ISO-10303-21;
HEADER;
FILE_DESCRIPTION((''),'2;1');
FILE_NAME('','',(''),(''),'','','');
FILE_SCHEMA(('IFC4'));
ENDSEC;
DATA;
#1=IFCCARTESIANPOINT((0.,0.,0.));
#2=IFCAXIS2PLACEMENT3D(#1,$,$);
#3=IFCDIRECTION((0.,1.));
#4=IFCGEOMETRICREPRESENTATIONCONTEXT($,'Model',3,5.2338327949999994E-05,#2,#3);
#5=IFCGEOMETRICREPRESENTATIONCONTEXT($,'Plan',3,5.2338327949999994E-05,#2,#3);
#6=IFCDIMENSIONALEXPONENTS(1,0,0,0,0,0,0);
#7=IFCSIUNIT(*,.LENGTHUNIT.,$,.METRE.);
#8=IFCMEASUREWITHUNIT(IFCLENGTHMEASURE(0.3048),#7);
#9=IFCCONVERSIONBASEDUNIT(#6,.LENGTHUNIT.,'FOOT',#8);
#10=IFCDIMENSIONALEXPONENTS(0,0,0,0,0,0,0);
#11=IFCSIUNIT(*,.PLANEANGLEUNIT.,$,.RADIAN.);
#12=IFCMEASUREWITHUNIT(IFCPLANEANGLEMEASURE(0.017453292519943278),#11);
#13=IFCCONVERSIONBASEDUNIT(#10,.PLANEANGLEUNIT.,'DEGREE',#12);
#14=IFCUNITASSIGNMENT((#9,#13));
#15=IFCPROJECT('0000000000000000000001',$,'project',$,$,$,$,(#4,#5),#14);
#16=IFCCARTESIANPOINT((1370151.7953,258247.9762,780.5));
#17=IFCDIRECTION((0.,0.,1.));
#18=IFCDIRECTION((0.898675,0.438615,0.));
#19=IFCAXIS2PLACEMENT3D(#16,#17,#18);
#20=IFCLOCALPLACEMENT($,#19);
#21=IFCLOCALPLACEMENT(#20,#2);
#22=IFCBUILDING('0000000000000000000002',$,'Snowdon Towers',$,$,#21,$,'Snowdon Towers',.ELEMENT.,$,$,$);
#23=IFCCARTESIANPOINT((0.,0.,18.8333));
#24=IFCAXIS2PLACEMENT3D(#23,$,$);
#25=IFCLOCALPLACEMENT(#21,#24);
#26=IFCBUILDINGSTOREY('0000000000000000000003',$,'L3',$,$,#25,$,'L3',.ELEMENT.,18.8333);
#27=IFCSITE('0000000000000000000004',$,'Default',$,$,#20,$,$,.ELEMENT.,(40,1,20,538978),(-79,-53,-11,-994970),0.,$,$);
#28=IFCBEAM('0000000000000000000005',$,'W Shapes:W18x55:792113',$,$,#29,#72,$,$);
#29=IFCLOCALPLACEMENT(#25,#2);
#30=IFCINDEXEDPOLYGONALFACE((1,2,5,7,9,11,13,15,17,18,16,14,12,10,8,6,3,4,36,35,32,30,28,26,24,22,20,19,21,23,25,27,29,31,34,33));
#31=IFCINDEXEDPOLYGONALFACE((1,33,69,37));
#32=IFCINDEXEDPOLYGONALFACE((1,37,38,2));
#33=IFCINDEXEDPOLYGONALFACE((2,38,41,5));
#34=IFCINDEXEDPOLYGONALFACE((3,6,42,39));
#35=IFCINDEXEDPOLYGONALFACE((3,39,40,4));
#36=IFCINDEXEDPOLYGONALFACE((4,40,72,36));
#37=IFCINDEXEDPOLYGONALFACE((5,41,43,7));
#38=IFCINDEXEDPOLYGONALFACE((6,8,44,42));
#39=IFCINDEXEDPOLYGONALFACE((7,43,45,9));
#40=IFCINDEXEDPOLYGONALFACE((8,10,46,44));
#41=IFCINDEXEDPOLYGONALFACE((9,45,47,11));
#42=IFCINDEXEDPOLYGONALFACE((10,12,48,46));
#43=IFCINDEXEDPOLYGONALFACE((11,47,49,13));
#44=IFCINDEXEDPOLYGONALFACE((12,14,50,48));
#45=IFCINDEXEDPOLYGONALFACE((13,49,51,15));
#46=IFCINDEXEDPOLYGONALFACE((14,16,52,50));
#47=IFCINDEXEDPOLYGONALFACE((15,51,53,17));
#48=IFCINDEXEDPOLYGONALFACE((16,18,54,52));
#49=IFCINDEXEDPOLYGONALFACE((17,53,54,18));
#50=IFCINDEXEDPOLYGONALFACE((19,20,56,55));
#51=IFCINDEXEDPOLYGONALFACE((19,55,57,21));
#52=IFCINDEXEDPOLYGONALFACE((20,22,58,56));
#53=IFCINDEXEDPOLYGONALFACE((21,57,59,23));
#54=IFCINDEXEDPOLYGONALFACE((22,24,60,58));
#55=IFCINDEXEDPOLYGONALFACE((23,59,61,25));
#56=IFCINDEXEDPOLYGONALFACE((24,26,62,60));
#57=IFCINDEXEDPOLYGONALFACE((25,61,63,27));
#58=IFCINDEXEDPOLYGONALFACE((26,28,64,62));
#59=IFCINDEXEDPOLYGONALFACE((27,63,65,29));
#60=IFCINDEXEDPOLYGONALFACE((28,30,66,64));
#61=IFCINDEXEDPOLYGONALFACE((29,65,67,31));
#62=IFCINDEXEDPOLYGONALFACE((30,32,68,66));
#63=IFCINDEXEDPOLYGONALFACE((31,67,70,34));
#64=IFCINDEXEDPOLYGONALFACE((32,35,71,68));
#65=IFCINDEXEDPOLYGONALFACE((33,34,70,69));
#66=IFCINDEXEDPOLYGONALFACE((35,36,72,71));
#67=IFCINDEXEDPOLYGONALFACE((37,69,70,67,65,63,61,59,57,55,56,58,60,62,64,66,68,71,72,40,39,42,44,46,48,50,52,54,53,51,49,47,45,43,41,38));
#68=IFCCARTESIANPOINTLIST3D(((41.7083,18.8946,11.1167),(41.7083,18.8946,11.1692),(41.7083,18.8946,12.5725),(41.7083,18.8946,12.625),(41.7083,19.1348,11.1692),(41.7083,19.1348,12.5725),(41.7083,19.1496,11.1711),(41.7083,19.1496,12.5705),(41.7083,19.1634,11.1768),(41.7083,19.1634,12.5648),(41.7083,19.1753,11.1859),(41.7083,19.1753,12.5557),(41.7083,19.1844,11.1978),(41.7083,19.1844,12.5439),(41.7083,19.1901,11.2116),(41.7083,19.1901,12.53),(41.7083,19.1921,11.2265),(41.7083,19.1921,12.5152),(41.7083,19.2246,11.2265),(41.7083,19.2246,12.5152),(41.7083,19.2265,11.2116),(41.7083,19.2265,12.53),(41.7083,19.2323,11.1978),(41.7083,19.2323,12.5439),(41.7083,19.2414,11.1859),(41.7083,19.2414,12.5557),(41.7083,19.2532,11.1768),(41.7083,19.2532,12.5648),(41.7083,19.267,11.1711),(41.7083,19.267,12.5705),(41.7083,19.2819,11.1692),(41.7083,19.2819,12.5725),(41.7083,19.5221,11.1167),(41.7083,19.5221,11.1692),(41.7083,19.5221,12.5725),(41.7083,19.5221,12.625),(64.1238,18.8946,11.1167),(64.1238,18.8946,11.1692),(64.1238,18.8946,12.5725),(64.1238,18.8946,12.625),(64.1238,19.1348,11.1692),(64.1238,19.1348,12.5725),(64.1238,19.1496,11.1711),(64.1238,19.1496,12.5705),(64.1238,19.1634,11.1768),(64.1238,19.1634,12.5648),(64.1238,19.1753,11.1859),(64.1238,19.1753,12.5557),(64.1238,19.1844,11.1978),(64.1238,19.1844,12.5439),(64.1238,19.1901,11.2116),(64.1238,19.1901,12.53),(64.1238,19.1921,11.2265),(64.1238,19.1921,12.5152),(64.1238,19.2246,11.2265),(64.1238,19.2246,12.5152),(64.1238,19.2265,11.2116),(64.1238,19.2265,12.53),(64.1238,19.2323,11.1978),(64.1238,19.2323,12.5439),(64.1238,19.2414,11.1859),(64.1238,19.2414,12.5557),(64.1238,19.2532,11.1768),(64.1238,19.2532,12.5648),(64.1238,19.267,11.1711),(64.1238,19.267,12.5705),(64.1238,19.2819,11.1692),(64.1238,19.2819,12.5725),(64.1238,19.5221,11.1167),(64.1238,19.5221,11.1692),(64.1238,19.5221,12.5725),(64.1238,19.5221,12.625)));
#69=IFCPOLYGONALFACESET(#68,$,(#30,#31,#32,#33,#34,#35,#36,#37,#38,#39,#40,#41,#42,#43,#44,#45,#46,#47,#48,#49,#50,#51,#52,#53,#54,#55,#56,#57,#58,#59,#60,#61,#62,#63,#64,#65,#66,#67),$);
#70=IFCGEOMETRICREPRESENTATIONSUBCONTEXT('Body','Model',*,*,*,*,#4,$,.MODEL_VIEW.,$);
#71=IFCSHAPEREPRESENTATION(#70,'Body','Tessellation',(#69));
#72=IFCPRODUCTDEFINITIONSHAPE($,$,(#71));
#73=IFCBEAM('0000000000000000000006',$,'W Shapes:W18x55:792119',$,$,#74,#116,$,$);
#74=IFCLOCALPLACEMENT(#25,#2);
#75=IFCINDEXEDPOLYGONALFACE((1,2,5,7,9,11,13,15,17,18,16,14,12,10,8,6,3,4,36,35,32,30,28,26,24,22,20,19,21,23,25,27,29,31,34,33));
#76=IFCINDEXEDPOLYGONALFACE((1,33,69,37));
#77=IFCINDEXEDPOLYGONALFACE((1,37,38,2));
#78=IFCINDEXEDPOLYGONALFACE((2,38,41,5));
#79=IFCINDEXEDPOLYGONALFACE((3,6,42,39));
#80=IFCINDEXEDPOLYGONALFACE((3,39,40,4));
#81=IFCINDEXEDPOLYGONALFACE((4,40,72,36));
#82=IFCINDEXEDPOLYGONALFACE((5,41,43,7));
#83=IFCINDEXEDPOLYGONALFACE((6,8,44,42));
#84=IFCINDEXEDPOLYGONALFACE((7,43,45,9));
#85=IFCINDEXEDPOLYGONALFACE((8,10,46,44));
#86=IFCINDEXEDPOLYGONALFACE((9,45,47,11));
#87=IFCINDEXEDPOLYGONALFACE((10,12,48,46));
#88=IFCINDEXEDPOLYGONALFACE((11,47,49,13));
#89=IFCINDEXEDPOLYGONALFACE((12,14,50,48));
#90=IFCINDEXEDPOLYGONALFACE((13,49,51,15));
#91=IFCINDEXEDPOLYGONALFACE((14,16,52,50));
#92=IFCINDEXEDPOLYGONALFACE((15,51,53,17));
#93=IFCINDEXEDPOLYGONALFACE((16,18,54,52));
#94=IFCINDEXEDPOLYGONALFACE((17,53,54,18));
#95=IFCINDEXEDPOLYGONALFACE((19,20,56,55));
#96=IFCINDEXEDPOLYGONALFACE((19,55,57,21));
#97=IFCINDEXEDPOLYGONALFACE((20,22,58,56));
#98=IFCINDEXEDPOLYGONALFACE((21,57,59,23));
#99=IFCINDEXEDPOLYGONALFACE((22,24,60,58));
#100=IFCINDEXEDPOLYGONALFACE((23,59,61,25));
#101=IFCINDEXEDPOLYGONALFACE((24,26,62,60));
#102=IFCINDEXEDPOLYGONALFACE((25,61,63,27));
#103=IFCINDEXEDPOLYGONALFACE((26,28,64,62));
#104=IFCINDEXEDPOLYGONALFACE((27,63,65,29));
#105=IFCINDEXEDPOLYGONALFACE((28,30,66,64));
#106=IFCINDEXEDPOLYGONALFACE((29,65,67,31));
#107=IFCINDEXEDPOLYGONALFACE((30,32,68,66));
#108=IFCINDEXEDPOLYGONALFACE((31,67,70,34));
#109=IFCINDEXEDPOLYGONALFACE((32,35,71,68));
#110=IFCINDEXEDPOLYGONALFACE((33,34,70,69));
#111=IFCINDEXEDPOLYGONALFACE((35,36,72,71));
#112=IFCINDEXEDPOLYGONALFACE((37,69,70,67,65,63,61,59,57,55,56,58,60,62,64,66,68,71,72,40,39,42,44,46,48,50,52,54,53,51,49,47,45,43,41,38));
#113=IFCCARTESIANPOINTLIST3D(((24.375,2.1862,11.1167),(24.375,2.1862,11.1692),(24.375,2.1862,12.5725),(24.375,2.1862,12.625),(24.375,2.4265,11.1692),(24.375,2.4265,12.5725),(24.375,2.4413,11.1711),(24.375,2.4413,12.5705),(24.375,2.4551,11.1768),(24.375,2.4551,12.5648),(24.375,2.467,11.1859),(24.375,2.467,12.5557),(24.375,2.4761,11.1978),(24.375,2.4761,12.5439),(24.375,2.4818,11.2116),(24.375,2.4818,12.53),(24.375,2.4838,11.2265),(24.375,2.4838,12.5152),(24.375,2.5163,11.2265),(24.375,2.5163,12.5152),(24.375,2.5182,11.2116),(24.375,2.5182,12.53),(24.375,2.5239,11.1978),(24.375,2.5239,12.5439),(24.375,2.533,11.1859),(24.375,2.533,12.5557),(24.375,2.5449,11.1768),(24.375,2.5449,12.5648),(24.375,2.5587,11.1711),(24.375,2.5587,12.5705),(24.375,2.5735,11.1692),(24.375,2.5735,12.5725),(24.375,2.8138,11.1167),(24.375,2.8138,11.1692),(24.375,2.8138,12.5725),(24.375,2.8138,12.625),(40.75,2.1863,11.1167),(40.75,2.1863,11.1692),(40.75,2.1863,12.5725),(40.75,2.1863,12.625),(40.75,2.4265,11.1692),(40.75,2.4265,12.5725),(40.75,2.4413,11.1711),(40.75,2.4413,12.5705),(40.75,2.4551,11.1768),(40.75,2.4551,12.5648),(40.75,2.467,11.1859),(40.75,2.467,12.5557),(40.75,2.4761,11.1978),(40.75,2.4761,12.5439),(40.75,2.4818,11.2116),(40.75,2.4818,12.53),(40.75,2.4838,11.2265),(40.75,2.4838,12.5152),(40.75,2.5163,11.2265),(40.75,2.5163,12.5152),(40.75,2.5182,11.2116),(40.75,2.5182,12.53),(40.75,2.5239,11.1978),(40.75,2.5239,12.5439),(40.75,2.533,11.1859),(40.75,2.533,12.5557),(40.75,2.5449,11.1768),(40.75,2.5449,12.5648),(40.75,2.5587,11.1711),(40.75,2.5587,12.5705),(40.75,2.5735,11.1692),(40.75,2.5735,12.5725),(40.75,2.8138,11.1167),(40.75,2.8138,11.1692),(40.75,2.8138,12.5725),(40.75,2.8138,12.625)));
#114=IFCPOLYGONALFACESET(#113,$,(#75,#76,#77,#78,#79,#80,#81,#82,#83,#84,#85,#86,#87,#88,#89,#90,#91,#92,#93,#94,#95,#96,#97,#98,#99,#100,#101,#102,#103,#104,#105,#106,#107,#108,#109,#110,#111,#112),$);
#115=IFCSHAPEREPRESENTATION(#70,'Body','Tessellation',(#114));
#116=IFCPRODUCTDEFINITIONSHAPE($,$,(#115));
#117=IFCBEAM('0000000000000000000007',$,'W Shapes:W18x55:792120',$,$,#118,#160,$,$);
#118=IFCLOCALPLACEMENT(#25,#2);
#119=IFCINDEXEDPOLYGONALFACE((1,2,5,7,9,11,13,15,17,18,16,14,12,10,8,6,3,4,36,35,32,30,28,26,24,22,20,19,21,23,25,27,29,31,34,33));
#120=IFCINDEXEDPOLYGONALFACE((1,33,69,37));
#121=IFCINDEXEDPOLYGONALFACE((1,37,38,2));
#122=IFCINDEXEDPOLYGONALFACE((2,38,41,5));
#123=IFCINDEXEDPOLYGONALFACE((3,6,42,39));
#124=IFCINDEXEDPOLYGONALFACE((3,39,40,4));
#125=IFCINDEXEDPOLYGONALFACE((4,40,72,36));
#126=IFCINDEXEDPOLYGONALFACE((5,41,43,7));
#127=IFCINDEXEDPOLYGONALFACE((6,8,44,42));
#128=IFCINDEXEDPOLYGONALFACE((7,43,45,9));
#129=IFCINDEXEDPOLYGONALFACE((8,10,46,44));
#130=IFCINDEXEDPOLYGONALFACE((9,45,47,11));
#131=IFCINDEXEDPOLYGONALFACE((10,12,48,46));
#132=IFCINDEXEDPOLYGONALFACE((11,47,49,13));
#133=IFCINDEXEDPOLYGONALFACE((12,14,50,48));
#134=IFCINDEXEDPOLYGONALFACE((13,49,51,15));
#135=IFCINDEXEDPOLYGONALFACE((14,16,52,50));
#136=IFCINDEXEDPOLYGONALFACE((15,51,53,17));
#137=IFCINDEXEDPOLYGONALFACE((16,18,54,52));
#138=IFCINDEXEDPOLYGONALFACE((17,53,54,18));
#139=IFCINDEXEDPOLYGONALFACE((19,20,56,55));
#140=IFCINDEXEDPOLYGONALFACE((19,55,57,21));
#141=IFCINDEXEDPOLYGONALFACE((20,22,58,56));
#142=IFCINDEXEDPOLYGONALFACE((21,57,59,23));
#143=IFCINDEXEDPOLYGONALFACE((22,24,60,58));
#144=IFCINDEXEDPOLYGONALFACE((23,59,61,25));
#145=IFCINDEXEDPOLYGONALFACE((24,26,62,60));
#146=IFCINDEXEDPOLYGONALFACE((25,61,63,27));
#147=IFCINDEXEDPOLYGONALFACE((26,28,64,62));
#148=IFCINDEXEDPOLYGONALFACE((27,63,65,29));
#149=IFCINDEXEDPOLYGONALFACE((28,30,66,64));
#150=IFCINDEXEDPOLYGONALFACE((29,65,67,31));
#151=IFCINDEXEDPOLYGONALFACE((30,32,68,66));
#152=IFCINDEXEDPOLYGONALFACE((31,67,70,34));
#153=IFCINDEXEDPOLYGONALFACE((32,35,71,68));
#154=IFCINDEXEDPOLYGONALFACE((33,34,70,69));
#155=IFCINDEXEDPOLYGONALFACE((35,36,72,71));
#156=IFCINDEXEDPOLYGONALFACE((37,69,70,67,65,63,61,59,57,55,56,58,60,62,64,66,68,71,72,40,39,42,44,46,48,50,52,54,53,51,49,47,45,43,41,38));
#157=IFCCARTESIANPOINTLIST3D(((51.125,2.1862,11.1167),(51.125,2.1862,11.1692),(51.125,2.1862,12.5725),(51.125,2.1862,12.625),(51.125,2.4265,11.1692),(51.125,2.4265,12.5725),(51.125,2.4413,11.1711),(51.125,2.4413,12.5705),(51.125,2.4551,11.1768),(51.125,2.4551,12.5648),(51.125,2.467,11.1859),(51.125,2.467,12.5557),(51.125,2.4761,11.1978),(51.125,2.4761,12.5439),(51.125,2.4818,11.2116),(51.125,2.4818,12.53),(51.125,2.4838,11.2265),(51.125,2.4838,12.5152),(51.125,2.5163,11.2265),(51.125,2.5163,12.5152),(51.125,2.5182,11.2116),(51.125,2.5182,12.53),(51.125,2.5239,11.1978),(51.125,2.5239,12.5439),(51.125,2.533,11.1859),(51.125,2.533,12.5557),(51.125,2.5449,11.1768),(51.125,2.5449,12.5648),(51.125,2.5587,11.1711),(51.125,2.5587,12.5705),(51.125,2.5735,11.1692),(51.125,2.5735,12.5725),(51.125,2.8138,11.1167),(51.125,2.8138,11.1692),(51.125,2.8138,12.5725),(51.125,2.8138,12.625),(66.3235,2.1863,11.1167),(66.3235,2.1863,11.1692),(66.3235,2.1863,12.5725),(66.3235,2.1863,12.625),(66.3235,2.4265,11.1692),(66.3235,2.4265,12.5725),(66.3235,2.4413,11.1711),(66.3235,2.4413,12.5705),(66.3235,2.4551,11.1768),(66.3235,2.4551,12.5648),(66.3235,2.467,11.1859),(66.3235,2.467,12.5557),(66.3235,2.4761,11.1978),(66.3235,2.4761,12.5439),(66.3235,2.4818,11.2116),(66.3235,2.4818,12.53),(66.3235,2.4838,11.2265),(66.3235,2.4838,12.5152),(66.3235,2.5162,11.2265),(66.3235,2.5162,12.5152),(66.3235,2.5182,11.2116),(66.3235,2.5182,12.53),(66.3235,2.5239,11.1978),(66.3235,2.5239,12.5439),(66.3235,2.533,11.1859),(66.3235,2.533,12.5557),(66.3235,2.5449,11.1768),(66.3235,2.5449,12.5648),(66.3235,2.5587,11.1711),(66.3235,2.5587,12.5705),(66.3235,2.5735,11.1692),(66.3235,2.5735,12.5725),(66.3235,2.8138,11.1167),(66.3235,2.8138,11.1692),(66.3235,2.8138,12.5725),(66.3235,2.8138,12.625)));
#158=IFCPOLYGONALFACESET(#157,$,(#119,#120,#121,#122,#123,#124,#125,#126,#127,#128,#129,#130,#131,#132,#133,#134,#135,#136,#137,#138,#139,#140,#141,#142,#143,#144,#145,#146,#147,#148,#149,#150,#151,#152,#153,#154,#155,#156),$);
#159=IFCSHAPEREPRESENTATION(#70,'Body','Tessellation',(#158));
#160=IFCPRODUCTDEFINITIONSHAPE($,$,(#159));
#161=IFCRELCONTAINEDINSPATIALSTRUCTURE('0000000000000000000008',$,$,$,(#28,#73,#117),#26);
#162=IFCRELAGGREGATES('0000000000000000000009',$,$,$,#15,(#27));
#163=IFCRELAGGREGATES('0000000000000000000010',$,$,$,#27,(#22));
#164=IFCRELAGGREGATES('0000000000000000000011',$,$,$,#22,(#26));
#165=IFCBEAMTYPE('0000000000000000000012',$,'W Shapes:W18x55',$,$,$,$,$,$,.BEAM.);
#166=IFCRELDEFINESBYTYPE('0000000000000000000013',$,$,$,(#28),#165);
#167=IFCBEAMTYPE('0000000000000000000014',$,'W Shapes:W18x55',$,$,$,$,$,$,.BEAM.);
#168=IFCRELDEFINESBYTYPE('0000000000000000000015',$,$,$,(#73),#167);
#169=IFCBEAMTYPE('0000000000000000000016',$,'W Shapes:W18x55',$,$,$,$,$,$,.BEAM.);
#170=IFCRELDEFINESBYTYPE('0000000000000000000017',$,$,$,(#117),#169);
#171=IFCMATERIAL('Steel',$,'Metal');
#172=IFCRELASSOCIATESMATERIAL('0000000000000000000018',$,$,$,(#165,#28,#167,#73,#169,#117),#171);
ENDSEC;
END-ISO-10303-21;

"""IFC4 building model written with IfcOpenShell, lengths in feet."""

from ifc_helpers import new_model, entity, si_unit, converted_unit, direction, frame, origin, place, context, subcontext, project, spatial, line, arc, indexed_curve, outline, extrude, source, transform, mapped, material, type_object, type_shapes, element, save


model = new_model("IFC4")

# Units and contexts
model_context = context("Model", 3, precision=5.2338327949999994e-05, world=origin(), true_north=direction((0.0, 1.0)))
plan_context = context("Plan", 3, precision=5.2338327949999994e-05, world=origin(), true_north=direction((0.0, 1.0)))
body_context = subcontext(model_context, "Body", "Model", "MODEL_VIEW")
ifc_project = project(units=[converted_unit("LENGTHUNIT", "FOOT", entity("IfcLengthMeasure", 0.3048), si_unit("LENGTHUNIT", "METRE"), dimensions=[1, 0, 0, 0, 0, 0, 0]), converted_unit("PLANEANGLEUNIT", "DEGREE", entity("IfcPlaneAngleMeasure", 0.017453292519943278), si_unit("PLANEANGLEUNIT", "RADIAN"), dimensions=[0, 0, 0, 0, 0, 0, 0])], contexts=[model_context, plan_context])

# Site, building, storey
site_placement = place(None, frame((1370151.7953, 258247.9762, 780.5), z_axis=(0.0, 0.0, 1.0), x_axis=(0.898675, 0.438615, 0.0)))
site = spatial("IfcSite", under=ifc_project, at=site_placement, Name="Default", CompositionType="ELEMENT", RefLatitude=(40, 1, 20, 538978), RefLongitude=(-79, -53, -11, -994970), RefElevation=0.0)
building_placement = place(site_placement, origin())
building = spatial("IfcBuilding", under=site, at=building_placement, Name="Snowdon Towers", LongName="Snowdon Towers", CompositionType="ELEMENT")
storey_placement = place(building_placement, frame((0.0, 0.0, 18.8333)))
storey = spatial("IfcBuildingStorey", under=building, at=storey_placement, Name="L3", LongName="L3", CompositionType="ELEMENT", Elevation=18.8333)

# Beams
ifc_material_1 = material(Name="Steel", Category="Metal")
beam_type_1 = type_object("IfcBeamType", Name="W Shapes:W18x55", PredefinedType="BEAM", material=ifc_material_1)
shared_shape_1 = source(origin(), body_context, "Body", "SweptSolid", [
    extrude(outline(indexed_curve([(-0.7542, -0.3138), (-0.7017, -0.3138), (-0.7017, -0.0735), (-0.6849, -0.033), (-0.6444, -0.0162), (0.6444, -0.0162), (0.6849, -0.033), (0.7017, -0.0735), (0.7017, -0.3138), (0.7542, -0.3138), (0.7542, 0.3138), (0.7017, 0.3138), (0.7017, 0.0735), (0.6849, 0.033), (0.6444, 0.0163), (-0.6444, 0.0163), (-0.6849, 0.033), (-0.7017, 0.0735), (-0.7017, 0.3137), (-0.7542, 0.3137)], segments=[line(1, 2, 3), arc(3, 4, 5), line(5, 6), arc(6, 7, 8), line(8, 9, 10, 11, 12, 13), arc(13, 14, 15), line(15, 16), arc(16, 17, 18), line(18, 19, 20, 1)], self_intersect=False)), frame((-11.5915, 0.0, 0.0), z_axis=(1.0, 0.0, 0.0), x_axis=(0.0, 0.0, -1.0)), (0.0, 0.0, 1.0), 22.4154),
])
type_shapes(beam_type_1, [shared_shape_1])
beam_1_placement = place(storey_placement, frame((53.2998, 19.2083, 11.8708)))
element("IfcBeam", 1, at=beam_1_placement, inside=storey, type_object=beam_type_1, material=ifc_material_1, Name="W Shapes:W18x55:792113", context=body_context, shape_type="MappedRepresentation", body=[
    mapped(shared_shape_1, transform((0.0, 0.0, 0.0), scale=1.0)),
])
beam_type_2 = type_object("IfcBeamType", Name="W Shapes:W18x55", PredefinedType="BEAM", material=ifc_material_1)
shared_shape_2 = source(origin(), body_context, "Body", "SweptSolid", [
    extrude(outline(indexed_curve([(-0.7542, -0.3138), (-0.7017, -0.3138), (-0.7017, -0.0735), (-0.6849, -0.033), (-0.6444, -0.0162), (0.6444, -0.0162), (0.6849, -0.033), (0.7017, -0.0735), (0.7017, -0.3138), (0.7542, -0.3138), (0.7542, 0.3138), (0.7017, 0.3138), (0.7017, 0.0735), (0.6849, 0.033), (0.6444, 0.0163), (-0.6444, 0.0163), (-0.6849, 0.033), (-0.7017, 0.0735), (-0.7017, 0.3137), (-0.7542, 0.3137)], segments=[line(1, 2, 3), arc(3, 4, 5), line(5, 6), arc(6, 7, 8), line(8, 9, 10, 11, 12, 13), arc(13, 14, 15), line(15, 16), arc(16, 17, 18), line(18, 19, 20, 1)], self_intersect=False)), frame((-7.9583, 0.0, 0.0), z_axis=(1.0, 0.0, 0.0), x_axis=(0.0, 0.0, -1.0)), (0.0, 0.0, 1.0), 16.375),
])
type_shapes(beam_type_2, [shared_shape_2])
beam_2_placement = place(storey_placement, frame((32.3333, 2.5, 11.8708)))
element("IfcBeam", 2, at=beam_2_placement, inside=storey, type_object=beam_type_2, material=ifc_material_1, Name="W Shapes:W18x55:792119", context=body_context, shape_type="MappedRepresentation", body=[
    mapped(shared_shape_2, transform((0.0, 0.0, 0.0), scale=1.0)),
])
beam_type_3 = type_object("IfcBeamType", Name="W Shapes:W18x55", PredefinedType="BEAM", material=ifc_material_1)
shared_shape_3 = source(origin(), body_context, "Body", "SweptSolid", [
    extrude(outline(indexed_curve([(-0.7542, -0.3138), (-0.7017, -0.3138), (-0.7017, -0.0735), (-0.6849, -0.033), (-0.6444, -0.0162), (0.6444, -0.0162), (0.6849, -0.033), (0.7017, -0.0735), (0.7017, -0.3138), (0.7542, -0.3138), (0.7542, 0.3138), (0.7017, 0.3138), (0.7017, 0.0735), (0.6849, 0.033), (0.6444, 0.0163), (-0.6444, 0.0163), (-0.6849, 0.033), (-0.7017, 0.0735), (-0.7017, 0.3137), (-0.7542, 0.3137)], segments=[line(1, 2, 3), arc(3, 4, 5), line(5, 6), arc(6, 7, 8), line(8, 9, 10, 11, 12, 13), arc(13, 14, 15), line(15, 16), arc(16, 17, 18), line(18, 19, 20, 1)], self_intersect=False)), frame((-8.2122, 0.0, 0.0), z_axis=(1.0, 0.0, 0.0), x_axis=(0.0, 0.0, -1.0)), (0.0, 0.0, 1.0), 15.1985),
])
type_shapes(beam_type_3, [shared_shape_3])
beam_3_placement = place(storey_placement, frame((59.3372, 2.5, 11.8708)))
element("IfcBeam", 3, at=beam_3_placement, inside=storey, type_object=beam_type_3, material=ifc_material_1, Name="W Shapes:W18x55:792120", context=body_context, shape_type="MappedRepresentation", body=[
    mapped(shared_shape_3, transform((0.0, 0.0, 0.0), scale=1.0)),
])

save(model, "model.ifc")
